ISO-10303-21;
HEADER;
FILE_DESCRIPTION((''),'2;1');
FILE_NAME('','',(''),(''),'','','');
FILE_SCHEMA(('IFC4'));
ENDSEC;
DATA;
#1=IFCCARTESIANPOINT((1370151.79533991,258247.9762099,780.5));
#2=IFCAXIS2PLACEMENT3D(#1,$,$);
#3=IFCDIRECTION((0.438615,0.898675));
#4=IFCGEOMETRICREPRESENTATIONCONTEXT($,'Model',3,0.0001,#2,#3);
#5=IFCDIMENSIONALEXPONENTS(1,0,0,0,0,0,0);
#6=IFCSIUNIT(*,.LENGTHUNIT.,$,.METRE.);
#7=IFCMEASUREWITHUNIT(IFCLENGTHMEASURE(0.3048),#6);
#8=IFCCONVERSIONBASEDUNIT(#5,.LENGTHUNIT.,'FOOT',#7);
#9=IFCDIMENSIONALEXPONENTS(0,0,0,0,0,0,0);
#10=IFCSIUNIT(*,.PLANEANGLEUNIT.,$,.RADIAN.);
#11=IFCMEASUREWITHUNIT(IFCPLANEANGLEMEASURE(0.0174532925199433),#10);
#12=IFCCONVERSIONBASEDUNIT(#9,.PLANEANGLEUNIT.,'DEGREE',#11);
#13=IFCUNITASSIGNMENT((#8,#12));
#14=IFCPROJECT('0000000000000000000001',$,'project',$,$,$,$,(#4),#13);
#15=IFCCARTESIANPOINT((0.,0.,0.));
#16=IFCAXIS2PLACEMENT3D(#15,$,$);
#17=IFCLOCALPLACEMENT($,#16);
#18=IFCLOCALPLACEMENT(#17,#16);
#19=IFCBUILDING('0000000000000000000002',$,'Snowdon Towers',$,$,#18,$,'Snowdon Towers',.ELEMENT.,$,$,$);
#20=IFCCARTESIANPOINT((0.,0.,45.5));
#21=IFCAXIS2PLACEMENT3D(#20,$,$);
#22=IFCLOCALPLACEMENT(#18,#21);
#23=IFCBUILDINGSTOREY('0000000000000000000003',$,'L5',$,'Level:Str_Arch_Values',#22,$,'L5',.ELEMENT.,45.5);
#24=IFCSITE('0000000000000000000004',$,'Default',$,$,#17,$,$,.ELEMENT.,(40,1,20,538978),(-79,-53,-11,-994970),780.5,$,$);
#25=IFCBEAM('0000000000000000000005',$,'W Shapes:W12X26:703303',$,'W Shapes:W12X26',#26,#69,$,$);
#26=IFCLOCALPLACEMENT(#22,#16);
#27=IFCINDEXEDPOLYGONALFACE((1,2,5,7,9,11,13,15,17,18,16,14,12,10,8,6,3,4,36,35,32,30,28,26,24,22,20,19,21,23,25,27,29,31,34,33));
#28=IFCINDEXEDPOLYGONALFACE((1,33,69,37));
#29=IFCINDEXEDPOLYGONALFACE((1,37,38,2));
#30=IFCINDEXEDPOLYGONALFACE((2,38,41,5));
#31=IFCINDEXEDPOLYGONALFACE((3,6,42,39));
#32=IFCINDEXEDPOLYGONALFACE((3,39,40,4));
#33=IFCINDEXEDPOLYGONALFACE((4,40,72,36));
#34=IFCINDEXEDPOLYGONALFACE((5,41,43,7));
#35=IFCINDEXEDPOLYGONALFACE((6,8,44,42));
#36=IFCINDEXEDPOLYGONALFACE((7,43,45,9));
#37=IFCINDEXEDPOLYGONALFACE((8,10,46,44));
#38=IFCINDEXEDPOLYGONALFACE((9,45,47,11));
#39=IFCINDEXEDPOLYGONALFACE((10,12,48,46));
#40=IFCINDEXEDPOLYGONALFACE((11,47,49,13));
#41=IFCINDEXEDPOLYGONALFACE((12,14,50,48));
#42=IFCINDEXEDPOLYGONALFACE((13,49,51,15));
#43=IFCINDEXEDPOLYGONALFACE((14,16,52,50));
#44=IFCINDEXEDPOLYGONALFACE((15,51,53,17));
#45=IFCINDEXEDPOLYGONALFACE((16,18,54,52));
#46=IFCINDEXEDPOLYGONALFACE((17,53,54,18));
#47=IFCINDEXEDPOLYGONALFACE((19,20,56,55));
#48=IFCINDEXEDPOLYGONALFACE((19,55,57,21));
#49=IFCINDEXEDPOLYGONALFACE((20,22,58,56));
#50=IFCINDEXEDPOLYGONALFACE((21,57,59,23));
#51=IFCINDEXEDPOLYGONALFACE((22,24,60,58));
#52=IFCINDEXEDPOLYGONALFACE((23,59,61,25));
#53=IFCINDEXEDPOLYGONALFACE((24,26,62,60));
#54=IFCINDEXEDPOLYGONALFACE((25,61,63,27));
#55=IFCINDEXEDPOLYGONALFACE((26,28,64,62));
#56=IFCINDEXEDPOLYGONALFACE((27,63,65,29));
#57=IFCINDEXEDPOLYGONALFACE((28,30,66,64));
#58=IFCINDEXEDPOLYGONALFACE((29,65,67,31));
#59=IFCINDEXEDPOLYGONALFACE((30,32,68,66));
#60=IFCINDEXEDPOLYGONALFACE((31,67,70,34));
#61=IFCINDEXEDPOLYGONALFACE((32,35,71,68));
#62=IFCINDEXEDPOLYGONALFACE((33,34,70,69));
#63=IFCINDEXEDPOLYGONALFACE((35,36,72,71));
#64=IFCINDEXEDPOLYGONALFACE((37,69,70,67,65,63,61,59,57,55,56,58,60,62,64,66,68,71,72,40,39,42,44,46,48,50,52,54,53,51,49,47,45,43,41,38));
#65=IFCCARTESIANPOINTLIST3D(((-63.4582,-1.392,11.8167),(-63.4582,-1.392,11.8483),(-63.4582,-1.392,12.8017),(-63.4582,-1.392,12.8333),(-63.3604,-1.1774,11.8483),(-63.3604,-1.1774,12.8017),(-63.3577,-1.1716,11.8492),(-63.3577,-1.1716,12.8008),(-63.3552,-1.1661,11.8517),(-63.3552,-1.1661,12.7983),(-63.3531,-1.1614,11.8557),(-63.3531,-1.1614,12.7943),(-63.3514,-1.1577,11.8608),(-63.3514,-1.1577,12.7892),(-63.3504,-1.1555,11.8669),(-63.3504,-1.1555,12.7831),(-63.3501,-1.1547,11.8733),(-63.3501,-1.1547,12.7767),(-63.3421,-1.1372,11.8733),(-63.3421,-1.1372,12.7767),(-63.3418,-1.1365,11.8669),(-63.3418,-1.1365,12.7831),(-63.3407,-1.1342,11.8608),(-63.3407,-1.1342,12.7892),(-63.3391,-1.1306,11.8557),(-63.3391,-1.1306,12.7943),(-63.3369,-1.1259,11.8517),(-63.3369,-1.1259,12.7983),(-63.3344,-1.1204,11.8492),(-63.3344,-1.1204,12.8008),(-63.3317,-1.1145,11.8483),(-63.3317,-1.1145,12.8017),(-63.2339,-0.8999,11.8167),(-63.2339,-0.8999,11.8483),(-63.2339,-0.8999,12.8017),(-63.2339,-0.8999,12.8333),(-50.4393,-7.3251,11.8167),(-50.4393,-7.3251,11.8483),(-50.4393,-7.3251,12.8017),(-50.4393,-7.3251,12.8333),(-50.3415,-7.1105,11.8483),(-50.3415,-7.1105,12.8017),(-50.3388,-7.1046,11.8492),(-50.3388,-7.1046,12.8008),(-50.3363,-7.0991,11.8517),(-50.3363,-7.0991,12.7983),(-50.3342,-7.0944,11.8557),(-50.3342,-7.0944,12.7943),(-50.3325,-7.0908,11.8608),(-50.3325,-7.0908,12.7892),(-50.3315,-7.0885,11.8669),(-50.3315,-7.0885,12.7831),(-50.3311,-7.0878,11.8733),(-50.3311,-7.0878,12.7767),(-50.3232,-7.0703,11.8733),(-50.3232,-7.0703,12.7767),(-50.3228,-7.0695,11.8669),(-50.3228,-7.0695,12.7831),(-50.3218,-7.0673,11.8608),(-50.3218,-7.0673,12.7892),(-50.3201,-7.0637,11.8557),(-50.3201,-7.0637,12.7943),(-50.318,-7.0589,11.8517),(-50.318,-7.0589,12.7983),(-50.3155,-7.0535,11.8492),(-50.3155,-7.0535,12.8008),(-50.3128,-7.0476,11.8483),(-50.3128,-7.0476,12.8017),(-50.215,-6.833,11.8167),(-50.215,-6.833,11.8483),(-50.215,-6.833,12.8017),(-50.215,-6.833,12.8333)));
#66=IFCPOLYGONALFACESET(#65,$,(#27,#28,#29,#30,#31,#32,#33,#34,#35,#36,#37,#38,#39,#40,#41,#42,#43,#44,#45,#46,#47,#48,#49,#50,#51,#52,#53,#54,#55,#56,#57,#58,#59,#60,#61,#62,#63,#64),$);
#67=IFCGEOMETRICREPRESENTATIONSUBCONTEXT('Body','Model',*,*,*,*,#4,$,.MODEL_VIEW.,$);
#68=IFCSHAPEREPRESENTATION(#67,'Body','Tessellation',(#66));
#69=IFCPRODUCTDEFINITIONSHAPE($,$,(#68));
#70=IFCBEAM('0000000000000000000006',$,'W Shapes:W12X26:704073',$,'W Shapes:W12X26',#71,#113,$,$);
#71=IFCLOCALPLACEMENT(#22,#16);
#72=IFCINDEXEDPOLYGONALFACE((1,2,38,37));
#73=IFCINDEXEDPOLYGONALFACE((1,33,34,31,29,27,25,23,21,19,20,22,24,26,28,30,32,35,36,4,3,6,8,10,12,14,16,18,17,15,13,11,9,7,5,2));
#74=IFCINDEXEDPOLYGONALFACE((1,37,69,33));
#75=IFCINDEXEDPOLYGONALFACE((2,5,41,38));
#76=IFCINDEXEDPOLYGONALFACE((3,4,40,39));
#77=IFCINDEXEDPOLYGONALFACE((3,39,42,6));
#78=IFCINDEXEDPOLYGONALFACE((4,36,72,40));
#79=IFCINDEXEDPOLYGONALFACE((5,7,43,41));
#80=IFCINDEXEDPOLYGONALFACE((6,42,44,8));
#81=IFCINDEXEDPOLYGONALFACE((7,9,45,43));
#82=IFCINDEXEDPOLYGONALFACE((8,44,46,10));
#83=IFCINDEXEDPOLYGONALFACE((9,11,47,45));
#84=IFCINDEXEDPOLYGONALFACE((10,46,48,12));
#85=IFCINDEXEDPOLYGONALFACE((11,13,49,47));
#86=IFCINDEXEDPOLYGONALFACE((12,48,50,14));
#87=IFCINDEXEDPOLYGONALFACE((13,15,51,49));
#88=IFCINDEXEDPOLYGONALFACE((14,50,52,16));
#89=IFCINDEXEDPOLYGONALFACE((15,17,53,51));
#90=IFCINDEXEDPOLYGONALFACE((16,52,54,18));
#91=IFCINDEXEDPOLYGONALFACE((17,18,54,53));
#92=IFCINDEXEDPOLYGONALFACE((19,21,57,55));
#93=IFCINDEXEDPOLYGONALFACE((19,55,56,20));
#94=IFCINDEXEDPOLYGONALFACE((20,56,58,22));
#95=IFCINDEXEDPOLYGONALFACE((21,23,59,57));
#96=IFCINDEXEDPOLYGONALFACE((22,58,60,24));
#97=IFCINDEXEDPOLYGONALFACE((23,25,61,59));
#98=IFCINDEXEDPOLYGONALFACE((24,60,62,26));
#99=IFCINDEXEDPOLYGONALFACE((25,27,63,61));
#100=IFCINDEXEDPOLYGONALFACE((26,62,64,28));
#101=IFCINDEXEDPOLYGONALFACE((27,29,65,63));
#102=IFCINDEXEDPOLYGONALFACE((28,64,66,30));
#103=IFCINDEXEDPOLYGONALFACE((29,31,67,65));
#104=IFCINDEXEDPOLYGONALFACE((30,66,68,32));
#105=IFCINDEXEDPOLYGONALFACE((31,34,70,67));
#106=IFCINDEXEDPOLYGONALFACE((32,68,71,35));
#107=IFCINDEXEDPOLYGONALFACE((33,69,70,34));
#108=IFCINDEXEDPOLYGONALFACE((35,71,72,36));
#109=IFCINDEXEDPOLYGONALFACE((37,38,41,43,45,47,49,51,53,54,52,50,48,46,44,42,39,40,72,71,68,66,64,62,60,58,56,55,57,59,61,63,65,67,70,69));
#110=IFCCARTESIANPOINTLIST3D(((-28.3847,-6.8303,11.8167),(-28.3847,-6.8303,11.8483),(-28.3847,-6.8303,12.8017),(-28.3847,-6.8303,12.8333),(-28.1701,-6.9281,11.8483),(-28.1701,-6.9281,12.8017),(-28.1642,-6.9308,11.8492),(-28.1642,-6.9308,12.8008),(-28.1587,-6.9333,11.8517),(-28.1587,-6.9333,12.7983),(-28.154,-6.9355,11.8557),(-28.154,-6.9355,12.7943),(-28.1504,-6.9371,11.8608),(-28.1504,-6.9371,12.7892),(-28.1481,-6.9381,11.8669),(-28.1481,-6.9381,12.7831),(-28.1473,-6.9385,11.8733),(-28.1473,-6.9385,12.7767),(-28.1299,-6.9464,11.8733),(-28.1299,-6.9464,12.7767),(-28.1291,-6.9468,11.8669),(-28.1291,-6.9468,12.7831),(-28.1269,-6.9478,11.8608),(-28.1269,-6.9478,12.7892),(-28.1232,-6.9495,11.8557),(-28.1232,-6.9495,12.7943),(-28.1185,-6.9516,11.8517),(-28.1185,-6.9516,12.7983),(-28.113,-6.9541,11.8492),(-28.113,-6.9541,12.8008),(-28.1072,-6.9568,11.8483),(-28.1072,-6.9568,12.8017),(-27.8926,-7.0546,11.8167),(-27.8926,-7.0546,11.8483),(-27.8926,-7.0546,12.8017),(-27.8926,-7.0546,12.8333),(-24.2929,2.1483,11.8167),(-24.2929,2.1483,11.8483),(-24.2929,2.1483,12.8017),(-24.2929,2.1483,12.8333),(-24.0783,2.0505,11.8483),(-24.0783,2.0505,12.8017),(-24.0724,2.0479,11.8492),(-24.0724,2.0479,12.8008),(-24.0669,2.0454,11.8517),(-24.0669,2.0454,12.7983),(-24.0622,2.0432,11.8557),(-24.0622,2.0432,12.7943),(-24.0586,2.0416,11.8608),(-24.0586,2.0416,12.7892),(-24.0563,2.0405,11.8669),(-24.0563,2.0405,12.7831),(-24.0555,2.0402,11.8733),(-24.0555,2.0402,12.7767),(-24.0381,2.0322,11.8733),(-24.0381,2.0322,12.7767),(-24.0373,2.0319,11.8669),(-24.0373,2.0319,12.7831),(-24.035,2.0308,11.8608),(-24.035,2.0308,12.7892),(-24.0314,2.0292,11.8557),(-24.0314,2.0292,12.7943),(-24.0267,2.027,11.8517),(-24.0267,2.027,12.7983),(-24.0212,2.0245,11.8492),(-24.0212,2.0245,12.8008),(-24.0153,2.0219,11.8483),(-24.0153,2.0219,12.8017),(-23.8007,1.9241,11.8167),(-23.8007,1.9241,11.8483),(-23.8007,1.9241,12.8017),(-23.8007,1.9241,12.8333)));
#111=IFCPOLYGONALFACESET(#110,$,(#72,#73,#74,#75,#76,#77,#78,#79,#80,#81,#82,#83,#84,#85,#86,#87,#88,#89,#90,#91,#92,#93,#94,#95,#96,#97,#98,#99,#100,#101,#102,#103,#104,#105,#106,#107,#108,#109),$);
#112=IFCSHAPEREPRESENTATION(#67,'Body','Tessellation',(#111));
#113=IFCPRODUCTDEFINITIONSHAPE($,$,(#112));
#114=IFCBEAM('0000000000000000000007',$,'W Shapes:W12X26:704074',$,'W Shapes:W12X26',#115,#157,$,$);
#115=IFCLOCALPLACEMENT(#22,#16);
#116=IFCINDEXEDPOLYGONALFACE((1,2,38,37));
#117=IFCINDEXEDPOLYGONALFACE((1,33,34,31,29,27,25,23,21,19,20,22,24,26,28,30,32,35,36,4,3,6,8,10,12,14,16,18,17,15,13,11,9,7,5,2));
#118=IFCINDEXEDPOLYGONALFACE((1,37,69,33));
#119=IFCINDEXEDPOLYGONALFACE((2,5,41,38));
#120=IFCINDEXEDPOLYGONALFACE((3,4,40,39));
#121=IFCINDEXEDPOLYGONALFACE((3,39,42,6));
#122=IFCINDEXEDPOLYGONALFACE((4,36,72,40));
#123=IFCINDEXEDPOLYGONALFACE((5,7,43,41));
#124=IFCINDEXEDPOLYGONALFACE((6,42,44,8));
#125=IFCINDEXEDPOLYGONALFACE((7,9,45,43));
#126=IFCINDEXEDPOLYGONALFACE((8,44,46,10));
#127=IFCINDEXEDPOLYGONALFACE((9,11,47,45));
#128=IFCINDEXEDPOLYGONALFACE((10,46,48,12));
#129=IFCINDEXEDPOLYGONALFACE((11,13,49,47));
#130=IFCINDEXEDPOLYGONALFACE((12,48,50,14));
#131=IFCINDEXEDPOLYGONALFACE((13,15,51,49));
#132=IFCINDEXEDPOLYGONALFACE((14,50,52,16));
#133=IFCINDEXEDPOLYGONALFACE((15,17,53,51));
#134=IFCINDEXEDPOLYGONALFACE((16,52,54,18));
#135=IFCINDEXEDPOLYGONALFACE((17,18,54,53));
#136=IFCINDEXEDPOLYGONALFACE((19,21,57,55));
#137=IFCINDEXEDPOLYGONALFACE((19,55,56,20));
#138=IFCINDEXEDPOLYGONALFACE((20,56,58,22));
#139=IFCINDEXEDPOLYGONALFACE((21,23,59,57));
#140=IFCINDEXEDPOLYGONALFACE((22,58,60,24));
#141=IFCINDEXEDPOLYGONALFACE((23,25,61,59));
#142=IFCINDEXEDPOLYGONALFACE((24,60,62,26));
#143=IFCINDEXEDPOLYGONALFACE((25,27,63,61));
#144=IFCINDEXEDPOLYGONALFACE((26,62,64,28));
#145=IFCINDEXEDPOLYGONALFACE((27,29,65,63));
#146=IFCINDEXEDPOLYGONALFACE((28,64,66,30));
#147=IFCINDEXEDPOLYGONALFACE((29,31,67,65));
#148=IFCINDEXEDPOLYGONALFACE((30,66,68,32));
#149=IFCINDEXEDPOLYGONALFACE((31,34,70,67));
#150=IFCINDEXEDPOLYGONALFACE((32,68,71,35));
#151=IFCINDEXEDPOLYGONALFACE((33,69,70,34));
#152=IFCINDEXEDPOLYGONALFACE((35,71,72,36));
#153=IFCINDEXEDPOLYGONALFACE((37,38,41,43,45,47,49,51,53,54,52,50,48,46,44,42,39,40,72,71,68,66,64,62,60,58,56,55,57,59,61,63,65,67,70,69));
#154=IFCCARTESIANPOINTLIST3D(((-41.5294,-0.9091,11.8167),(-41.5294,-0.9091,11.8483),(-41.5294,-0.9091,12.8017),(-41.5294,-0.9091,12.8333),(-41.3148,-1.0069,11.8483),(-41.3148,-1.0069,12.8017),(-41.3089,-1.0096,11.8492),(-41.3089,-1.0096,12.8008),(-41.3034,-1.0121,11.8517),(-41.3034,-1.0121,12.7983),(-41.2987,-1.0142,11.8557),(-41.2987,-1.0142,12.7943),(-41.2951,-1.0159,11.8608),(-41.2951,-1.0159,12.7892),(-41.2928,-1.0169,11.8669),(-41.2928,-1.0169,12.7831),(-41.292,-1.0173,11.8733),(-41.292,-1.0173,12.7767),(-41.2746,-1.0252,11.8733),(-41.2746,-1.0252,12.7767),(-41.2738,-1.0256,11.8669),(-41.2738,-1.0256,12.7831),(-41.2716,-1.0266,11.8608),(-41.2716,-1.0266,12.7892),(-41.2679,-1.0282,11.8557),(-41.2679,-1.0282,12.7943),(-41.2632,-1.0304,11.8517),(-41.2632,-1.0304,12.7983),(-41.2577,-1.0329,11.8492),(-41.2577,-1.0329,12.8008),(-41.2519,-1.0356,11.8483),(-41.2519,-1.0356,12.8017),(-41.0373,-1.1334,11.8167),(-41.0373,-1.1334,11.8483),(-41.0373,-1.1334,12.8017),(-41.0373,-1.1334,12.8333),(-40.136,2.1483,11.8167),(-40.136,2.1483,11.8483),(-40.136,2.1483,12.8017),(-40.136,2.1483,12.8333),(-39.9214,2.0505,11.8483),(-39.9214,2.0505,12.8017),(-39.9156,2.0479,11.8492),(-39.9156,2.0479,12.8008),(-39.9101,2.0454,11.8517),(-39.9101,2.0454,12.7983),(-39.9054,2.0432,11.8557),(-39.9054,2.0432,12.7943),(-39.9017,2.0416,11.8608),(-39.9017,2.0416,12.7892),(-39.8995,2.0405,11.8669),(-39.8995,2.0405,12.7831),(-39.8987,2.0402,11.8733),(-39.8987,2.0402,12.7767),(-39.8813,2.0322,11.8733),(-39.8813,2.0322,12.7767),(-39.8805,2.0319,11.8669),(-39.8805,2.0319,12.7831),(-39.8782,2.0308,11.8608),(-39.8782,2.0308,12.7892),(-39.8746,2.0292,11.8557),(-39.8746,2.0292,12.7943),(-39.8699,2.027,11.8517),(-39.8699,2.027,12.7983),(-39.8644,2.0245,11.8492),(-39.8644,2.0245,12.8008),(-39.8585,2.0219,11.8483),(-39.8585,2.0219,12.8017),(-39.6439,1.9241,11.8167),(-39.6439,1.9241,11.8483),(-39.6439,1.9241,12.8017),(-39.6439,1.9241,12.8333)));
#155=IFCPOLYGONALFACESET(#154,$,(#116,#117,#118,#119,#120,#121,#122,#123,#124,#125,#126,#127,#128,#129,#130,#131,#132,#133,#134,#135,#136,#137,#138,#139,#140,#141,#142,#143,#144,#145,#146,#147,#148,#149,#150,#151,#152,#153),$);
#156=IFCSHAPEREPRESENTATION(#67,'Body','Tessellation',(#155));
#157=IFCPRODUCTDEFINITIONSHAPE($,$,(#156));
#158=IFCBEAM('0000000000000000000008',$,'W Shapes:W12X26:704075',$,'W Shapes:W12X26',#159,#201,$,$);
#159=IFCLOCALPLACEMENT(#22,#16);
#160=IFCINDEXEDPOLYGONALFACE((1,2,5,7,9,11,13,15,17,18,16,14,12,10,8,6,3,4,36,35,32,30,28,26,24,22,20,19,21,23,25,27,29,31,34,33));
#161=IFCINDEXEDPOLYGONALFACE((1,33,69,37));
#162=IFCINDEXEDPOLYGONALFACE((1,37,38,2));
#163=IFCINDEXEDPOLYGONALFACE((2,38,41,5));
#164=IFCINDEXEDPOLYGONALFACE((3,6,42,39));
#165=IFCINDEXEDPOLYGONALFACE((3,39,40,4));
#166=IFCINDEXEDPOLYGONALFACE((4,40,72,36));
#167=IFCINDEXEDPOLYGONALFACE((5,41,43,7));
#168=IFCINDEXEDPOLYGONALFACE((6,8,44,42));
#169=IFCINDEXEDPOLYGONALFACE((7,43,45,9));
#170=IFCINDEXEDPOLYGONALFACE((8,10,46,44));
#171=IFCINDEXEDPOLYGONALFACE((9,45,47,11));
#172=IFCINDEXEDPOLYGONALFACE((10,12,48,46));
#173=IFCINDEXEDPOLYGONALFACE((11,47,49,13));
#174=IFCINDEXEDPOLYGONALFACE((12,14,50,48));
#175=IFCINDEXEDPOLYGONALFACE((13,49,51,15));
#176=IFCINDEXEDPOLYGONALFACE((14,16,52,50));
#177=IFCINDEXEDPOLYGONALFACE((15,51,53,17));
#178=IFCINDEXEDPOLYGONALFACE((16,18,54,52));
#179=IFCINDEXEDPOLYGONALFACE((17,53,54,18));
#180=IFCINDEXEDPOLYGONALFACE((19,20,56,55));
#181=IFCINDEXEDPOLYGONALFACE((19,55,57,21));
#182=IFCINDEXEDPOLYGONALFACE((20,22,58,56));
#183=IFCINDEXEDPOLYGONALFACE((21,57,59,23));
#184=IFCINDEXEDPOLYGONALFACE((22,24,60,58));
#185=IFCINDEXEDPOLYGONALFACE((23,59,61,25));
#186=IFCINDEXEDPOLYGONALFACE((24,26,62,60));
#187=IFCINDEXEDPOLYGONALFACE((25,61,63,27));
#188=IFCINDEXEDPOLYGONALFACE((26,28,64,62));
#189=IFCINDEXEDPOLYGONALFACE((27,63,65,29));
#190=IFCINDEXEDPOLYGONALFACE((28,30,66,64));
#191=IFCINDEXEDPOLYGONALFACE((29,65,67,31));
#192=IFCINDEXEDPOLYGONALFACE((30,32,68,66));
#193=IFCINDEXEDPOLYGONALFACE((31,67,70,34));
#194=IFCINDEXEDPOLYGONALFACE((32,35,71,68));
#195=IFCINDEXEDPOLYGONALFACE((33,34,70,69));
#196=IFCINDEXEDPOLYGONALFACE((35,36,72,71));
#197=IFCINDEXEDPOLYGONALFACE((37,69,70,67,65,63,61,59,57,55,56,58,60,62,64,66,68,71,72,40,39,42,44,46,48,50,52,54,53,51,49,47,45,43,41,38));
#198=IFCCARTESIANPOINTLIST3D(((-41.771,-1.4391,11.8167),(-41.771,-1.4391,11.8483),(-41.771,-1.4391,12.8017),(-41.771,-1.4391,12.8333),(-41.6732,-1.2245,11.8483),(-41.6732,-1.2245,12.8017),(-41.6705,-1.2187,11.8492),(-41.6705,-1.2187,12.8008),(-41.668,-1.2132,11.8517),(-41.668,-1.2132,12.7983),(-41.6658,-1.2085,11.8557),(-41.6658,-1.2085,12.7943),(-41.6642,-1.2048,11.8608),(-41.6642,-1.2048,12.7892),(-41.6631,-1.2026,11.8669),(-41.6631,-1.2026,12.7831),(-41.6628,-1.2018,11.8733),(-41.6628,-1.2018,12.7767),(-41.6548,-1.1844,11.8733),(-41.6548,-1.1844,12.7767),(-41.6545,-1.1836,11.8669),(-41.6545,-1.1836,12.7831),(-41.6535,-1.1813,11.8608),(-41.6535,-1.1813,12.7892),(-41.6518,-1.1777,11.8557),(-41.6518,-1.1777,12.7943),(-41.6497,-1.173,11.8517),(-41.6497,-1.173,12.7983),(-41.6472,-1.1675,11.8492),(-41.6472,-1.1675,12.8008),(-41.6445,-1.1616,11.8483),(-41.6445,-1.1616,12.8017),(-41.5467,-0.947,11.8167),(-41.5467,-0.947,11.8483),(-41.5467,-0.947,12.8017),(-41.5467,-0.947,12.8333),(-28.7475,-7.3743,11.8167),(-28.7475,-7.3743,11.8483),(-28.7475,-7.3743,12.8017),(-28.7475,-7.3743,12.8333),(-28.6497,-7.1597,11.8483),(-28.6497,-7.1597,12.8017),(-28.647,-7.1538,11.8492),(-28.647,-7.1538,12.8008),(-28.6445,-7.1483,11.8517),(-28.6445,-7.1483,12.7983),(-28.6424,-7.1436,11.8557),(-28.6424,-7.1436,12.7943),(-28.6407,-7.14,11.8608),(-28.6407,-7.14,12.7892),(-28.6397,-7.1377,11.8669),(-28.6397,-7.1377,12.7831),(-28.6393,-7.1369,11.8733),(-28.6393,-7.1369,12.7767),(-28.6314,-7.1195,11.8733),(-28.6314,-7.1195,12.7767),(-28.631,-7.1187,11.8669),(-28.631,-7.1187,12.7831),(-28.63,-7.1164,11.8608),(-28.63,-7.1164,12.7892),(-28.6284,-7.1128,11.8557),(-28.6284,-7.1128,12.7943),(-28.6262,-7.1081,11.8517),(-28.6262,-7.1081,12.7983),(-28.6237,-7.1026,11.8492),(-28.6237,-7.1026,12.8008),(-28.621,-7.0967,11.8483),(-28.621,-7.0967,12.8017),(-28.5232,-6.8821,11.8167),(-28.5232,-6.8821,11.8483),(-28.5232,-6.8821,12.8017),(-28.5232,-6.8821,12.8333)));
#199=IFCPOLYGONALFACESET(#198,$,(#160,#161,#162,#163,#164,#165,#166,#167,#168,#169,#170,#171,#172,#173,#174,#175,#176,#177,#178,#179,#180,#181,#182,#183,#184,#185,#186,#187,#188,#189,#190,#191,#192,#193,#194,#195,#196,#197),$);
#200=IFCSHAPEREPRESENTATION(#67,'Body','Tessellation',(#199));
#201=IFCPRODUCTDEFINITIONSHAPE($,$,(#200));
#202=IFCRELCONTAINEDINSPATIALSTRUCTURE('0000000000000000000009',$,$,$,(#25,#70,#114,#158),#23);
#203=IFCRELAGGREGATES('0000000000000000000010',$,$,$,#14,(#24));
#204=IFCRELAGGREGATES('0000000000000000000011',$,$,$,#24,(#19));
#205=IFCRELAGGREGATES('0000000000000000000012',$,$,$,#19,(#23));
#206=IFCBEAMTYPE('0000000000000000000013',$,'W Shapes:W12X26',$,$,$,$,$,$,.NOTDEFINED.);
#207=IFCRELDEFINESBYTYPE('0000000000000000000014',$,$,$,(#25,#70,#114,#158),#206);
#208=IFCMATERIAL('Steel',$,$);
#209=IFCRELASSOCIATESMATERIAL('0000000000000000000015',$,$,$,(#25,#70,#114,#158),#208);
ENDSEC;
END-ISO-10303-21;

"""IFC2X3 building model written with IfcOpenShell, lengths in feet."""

from ifc_helpers import new_model, entity, si_unit, converted_unit, direction, frame, frame_2d, origin, place, context, subcontext, project, spatial, i_section, extrude, material, type_object, element, save


model = new_model("IFC2X3")

# Units and contexts
model_context = context("Model", 3, precision=0.0001, world=frame((1370151.79533991, 258247.9762099, 780.5)), true_north=direction((0.438615, 0.898675)))
body_context = subcontext(model_context, "Body", "Model", "MODEL_VIEW")
ifc_project = project(units=[converted_unit("LENGTHUNIT", "FOOT", entity("IfcLengthMeasure", 0.3048), si_unit("LENGTHUNIT", "METRE"), dimensions=[1, 0, 0, 0, 0, 0, 0]), converted_unit("PLANEANGLEUNIT", "DEGREE", entity("IfcPlaneAngleMeasure", 0.0174532925199433), si_unit("PLANEANGLEUNIT", "RADIAN"), dimensions=[0, 0, 0, 0, 0, 0, 0])], contexts=[model_context])

# Site, building, storey
site_placement = place(None, origin())
site = spatial("IfcSite", under=ifc_project, at=site_placement, Name="Default", CompositionType="ELEMENT", RefLatitude=(40, 1, 20, 538978), RefLongitude=(-79, -53, -11, -994970), RefElevation=780.5)
building_placement = place(site_placement, origin())
building = spatial("IfcBuilding", under=site, at=building_placement, Name="Snowdon Towers", LongName="Snowdon Towers", CompositionType="ELEMENT")
storey_placement = place(building_placement, frame((0.0, 0.0, 45.5)))
storey = spatial("IfcBuildingStorey", under=building, at=storey_placement, Name="L5", ObjectType="Level:Str_Arch_Values", LongName="L5", CompositionType="ELEMENT", Elevation=45.5)

# Shared definitions
ifc_material_1 = material(Name="Steel")

# Beams
beam_type_1 = type_object("IfcBeamType", Name="W Shapes:W12X26", PredefinedType="NOTDEFINED")
beam_1_placement = place(storey_placement, frame((-63.1, -1.2581, 12.8333), z_axis=(0.0, 0.0, 1.0), x_axis=(0.909961, -0.414693, 0.0)))
element("IfcBeam", 1, at=beam_1_placement, inside=storey, type_object=beam_type_1, material=ifc_material_1, Name="W Shapes:W12X26:703303", ObjectType="W Shapes:W12X26", context=body_context, shape_type="SweptSolid", body=[
    extrude(i_section(OverallWidth=0.5408, OverallDepth=1.0167, WebThickness=0.0192, FlangeThickness=0.0317, FilletRadius=0.025, at=frame_2d((0.0, 0.0), x_axis=(0.0, 1.0))), frame((-0.2704, 0.0, -0.5083), z_axis=(1.0, 0.0, 0.0), x_axis=(0.0, 0.0, -1.0)), (0.0, 0.0, 1.0), 14.3071),
])
beam_2_placement = place(storey_placement, frame((-28.2941, -7.2837, 12.8333), z_axis=(0.0, 0.0, 1.0), x_axis=(0.414693, 0.909961, 0.0)))
element("IfcBeam", 2, at=beam_2_placement, inside=storey, type_object=beam_type_1, material=ifc_material_1, Name="W Shapes:W12X26:704073", ObjectType="W Shapes:W12X26", context=body_context, shape_type="SweptSolid", body=[
    extrude(i_section(OverallWidth=0.5408, OverallDepth=1.0167, WebThickness=0.0192, FlangeThickness=0.0317, FilletRadius=0.025, at=frame_2d((0.0, 0.0), x_axis=(0.0, 1.0))), frame((0.375, 0.0, -0.5083), z_axis=(1.0, 0.0, 0.0), x_axis=(0.0, 0.0, -1.0)), (0.0, 0.0, 1.0), 9.8671),
])
beam_3_placement = place(storey_placement, frame((-41.4127, -1.3052, 12.8333), z_axis=(0.0, 0.0, 1.0), x_axis=(0.414693, 0.909961, 0.0)))
element("IfcBeam", 3, at=beam_3_placement, inside=storey, type_object=beam_type_1, material=ifc_material_1, Name="W Shapes:W12X26:704074", ObjectType="W Shapes:W12X26", context=body_context, shape_type="SweptSolid", body=[
    extrude(i_section(OverallWidth=0.5408, OverallDepth=1.0167, WebThickness=0.0192, FlangeThickness=0.0317, FilletRadius=0.025, at=frame_2d((0.0, 0.0), x_axis=(0.0, 1.0))), frame((0.3121, 0.0, -0.5083), z_axis=(1.0, 0.0, 0.0), x_axis=(0.0, 0.0, -1.0)), (0.0, 0.0, 1.0), 3.3599),
])
beam_4_placement = place(storey_placement, frame((-41.4127, -1.3052, 12.8333), z_axis=(0.0, 0.0, 1.0), x_axis=(0.909961, -0.414693, 0.0)))
element("IfcBeam", 4, at=beam_4_placement, inside=storey, type_object=beam_type_1, material=ifc_material_1, Name="W Shapes:W12X26:704075", ObjectType="W Shapes:W12X26", context=body_context, shape_type="SweptSolid", body=[
    extrude(i_section(OverallWidth=0.5408, OverallDepth=1.0167, WebThickness=0.0192, FlangeThickness=0.0317, FilletRadius=0.025, at=frame_2d((0.0, 0.0), x_axis=(0.0, 1.0))), frame((-0.2704, 0.0, -0.5083), z_axis=(1.0, 0.0, 0.0), x_axis=(0.0, 0.0, -1.0)), (0.0, 0.0, 1.0), 14.3121),
])

save(model, "model.ifc")
